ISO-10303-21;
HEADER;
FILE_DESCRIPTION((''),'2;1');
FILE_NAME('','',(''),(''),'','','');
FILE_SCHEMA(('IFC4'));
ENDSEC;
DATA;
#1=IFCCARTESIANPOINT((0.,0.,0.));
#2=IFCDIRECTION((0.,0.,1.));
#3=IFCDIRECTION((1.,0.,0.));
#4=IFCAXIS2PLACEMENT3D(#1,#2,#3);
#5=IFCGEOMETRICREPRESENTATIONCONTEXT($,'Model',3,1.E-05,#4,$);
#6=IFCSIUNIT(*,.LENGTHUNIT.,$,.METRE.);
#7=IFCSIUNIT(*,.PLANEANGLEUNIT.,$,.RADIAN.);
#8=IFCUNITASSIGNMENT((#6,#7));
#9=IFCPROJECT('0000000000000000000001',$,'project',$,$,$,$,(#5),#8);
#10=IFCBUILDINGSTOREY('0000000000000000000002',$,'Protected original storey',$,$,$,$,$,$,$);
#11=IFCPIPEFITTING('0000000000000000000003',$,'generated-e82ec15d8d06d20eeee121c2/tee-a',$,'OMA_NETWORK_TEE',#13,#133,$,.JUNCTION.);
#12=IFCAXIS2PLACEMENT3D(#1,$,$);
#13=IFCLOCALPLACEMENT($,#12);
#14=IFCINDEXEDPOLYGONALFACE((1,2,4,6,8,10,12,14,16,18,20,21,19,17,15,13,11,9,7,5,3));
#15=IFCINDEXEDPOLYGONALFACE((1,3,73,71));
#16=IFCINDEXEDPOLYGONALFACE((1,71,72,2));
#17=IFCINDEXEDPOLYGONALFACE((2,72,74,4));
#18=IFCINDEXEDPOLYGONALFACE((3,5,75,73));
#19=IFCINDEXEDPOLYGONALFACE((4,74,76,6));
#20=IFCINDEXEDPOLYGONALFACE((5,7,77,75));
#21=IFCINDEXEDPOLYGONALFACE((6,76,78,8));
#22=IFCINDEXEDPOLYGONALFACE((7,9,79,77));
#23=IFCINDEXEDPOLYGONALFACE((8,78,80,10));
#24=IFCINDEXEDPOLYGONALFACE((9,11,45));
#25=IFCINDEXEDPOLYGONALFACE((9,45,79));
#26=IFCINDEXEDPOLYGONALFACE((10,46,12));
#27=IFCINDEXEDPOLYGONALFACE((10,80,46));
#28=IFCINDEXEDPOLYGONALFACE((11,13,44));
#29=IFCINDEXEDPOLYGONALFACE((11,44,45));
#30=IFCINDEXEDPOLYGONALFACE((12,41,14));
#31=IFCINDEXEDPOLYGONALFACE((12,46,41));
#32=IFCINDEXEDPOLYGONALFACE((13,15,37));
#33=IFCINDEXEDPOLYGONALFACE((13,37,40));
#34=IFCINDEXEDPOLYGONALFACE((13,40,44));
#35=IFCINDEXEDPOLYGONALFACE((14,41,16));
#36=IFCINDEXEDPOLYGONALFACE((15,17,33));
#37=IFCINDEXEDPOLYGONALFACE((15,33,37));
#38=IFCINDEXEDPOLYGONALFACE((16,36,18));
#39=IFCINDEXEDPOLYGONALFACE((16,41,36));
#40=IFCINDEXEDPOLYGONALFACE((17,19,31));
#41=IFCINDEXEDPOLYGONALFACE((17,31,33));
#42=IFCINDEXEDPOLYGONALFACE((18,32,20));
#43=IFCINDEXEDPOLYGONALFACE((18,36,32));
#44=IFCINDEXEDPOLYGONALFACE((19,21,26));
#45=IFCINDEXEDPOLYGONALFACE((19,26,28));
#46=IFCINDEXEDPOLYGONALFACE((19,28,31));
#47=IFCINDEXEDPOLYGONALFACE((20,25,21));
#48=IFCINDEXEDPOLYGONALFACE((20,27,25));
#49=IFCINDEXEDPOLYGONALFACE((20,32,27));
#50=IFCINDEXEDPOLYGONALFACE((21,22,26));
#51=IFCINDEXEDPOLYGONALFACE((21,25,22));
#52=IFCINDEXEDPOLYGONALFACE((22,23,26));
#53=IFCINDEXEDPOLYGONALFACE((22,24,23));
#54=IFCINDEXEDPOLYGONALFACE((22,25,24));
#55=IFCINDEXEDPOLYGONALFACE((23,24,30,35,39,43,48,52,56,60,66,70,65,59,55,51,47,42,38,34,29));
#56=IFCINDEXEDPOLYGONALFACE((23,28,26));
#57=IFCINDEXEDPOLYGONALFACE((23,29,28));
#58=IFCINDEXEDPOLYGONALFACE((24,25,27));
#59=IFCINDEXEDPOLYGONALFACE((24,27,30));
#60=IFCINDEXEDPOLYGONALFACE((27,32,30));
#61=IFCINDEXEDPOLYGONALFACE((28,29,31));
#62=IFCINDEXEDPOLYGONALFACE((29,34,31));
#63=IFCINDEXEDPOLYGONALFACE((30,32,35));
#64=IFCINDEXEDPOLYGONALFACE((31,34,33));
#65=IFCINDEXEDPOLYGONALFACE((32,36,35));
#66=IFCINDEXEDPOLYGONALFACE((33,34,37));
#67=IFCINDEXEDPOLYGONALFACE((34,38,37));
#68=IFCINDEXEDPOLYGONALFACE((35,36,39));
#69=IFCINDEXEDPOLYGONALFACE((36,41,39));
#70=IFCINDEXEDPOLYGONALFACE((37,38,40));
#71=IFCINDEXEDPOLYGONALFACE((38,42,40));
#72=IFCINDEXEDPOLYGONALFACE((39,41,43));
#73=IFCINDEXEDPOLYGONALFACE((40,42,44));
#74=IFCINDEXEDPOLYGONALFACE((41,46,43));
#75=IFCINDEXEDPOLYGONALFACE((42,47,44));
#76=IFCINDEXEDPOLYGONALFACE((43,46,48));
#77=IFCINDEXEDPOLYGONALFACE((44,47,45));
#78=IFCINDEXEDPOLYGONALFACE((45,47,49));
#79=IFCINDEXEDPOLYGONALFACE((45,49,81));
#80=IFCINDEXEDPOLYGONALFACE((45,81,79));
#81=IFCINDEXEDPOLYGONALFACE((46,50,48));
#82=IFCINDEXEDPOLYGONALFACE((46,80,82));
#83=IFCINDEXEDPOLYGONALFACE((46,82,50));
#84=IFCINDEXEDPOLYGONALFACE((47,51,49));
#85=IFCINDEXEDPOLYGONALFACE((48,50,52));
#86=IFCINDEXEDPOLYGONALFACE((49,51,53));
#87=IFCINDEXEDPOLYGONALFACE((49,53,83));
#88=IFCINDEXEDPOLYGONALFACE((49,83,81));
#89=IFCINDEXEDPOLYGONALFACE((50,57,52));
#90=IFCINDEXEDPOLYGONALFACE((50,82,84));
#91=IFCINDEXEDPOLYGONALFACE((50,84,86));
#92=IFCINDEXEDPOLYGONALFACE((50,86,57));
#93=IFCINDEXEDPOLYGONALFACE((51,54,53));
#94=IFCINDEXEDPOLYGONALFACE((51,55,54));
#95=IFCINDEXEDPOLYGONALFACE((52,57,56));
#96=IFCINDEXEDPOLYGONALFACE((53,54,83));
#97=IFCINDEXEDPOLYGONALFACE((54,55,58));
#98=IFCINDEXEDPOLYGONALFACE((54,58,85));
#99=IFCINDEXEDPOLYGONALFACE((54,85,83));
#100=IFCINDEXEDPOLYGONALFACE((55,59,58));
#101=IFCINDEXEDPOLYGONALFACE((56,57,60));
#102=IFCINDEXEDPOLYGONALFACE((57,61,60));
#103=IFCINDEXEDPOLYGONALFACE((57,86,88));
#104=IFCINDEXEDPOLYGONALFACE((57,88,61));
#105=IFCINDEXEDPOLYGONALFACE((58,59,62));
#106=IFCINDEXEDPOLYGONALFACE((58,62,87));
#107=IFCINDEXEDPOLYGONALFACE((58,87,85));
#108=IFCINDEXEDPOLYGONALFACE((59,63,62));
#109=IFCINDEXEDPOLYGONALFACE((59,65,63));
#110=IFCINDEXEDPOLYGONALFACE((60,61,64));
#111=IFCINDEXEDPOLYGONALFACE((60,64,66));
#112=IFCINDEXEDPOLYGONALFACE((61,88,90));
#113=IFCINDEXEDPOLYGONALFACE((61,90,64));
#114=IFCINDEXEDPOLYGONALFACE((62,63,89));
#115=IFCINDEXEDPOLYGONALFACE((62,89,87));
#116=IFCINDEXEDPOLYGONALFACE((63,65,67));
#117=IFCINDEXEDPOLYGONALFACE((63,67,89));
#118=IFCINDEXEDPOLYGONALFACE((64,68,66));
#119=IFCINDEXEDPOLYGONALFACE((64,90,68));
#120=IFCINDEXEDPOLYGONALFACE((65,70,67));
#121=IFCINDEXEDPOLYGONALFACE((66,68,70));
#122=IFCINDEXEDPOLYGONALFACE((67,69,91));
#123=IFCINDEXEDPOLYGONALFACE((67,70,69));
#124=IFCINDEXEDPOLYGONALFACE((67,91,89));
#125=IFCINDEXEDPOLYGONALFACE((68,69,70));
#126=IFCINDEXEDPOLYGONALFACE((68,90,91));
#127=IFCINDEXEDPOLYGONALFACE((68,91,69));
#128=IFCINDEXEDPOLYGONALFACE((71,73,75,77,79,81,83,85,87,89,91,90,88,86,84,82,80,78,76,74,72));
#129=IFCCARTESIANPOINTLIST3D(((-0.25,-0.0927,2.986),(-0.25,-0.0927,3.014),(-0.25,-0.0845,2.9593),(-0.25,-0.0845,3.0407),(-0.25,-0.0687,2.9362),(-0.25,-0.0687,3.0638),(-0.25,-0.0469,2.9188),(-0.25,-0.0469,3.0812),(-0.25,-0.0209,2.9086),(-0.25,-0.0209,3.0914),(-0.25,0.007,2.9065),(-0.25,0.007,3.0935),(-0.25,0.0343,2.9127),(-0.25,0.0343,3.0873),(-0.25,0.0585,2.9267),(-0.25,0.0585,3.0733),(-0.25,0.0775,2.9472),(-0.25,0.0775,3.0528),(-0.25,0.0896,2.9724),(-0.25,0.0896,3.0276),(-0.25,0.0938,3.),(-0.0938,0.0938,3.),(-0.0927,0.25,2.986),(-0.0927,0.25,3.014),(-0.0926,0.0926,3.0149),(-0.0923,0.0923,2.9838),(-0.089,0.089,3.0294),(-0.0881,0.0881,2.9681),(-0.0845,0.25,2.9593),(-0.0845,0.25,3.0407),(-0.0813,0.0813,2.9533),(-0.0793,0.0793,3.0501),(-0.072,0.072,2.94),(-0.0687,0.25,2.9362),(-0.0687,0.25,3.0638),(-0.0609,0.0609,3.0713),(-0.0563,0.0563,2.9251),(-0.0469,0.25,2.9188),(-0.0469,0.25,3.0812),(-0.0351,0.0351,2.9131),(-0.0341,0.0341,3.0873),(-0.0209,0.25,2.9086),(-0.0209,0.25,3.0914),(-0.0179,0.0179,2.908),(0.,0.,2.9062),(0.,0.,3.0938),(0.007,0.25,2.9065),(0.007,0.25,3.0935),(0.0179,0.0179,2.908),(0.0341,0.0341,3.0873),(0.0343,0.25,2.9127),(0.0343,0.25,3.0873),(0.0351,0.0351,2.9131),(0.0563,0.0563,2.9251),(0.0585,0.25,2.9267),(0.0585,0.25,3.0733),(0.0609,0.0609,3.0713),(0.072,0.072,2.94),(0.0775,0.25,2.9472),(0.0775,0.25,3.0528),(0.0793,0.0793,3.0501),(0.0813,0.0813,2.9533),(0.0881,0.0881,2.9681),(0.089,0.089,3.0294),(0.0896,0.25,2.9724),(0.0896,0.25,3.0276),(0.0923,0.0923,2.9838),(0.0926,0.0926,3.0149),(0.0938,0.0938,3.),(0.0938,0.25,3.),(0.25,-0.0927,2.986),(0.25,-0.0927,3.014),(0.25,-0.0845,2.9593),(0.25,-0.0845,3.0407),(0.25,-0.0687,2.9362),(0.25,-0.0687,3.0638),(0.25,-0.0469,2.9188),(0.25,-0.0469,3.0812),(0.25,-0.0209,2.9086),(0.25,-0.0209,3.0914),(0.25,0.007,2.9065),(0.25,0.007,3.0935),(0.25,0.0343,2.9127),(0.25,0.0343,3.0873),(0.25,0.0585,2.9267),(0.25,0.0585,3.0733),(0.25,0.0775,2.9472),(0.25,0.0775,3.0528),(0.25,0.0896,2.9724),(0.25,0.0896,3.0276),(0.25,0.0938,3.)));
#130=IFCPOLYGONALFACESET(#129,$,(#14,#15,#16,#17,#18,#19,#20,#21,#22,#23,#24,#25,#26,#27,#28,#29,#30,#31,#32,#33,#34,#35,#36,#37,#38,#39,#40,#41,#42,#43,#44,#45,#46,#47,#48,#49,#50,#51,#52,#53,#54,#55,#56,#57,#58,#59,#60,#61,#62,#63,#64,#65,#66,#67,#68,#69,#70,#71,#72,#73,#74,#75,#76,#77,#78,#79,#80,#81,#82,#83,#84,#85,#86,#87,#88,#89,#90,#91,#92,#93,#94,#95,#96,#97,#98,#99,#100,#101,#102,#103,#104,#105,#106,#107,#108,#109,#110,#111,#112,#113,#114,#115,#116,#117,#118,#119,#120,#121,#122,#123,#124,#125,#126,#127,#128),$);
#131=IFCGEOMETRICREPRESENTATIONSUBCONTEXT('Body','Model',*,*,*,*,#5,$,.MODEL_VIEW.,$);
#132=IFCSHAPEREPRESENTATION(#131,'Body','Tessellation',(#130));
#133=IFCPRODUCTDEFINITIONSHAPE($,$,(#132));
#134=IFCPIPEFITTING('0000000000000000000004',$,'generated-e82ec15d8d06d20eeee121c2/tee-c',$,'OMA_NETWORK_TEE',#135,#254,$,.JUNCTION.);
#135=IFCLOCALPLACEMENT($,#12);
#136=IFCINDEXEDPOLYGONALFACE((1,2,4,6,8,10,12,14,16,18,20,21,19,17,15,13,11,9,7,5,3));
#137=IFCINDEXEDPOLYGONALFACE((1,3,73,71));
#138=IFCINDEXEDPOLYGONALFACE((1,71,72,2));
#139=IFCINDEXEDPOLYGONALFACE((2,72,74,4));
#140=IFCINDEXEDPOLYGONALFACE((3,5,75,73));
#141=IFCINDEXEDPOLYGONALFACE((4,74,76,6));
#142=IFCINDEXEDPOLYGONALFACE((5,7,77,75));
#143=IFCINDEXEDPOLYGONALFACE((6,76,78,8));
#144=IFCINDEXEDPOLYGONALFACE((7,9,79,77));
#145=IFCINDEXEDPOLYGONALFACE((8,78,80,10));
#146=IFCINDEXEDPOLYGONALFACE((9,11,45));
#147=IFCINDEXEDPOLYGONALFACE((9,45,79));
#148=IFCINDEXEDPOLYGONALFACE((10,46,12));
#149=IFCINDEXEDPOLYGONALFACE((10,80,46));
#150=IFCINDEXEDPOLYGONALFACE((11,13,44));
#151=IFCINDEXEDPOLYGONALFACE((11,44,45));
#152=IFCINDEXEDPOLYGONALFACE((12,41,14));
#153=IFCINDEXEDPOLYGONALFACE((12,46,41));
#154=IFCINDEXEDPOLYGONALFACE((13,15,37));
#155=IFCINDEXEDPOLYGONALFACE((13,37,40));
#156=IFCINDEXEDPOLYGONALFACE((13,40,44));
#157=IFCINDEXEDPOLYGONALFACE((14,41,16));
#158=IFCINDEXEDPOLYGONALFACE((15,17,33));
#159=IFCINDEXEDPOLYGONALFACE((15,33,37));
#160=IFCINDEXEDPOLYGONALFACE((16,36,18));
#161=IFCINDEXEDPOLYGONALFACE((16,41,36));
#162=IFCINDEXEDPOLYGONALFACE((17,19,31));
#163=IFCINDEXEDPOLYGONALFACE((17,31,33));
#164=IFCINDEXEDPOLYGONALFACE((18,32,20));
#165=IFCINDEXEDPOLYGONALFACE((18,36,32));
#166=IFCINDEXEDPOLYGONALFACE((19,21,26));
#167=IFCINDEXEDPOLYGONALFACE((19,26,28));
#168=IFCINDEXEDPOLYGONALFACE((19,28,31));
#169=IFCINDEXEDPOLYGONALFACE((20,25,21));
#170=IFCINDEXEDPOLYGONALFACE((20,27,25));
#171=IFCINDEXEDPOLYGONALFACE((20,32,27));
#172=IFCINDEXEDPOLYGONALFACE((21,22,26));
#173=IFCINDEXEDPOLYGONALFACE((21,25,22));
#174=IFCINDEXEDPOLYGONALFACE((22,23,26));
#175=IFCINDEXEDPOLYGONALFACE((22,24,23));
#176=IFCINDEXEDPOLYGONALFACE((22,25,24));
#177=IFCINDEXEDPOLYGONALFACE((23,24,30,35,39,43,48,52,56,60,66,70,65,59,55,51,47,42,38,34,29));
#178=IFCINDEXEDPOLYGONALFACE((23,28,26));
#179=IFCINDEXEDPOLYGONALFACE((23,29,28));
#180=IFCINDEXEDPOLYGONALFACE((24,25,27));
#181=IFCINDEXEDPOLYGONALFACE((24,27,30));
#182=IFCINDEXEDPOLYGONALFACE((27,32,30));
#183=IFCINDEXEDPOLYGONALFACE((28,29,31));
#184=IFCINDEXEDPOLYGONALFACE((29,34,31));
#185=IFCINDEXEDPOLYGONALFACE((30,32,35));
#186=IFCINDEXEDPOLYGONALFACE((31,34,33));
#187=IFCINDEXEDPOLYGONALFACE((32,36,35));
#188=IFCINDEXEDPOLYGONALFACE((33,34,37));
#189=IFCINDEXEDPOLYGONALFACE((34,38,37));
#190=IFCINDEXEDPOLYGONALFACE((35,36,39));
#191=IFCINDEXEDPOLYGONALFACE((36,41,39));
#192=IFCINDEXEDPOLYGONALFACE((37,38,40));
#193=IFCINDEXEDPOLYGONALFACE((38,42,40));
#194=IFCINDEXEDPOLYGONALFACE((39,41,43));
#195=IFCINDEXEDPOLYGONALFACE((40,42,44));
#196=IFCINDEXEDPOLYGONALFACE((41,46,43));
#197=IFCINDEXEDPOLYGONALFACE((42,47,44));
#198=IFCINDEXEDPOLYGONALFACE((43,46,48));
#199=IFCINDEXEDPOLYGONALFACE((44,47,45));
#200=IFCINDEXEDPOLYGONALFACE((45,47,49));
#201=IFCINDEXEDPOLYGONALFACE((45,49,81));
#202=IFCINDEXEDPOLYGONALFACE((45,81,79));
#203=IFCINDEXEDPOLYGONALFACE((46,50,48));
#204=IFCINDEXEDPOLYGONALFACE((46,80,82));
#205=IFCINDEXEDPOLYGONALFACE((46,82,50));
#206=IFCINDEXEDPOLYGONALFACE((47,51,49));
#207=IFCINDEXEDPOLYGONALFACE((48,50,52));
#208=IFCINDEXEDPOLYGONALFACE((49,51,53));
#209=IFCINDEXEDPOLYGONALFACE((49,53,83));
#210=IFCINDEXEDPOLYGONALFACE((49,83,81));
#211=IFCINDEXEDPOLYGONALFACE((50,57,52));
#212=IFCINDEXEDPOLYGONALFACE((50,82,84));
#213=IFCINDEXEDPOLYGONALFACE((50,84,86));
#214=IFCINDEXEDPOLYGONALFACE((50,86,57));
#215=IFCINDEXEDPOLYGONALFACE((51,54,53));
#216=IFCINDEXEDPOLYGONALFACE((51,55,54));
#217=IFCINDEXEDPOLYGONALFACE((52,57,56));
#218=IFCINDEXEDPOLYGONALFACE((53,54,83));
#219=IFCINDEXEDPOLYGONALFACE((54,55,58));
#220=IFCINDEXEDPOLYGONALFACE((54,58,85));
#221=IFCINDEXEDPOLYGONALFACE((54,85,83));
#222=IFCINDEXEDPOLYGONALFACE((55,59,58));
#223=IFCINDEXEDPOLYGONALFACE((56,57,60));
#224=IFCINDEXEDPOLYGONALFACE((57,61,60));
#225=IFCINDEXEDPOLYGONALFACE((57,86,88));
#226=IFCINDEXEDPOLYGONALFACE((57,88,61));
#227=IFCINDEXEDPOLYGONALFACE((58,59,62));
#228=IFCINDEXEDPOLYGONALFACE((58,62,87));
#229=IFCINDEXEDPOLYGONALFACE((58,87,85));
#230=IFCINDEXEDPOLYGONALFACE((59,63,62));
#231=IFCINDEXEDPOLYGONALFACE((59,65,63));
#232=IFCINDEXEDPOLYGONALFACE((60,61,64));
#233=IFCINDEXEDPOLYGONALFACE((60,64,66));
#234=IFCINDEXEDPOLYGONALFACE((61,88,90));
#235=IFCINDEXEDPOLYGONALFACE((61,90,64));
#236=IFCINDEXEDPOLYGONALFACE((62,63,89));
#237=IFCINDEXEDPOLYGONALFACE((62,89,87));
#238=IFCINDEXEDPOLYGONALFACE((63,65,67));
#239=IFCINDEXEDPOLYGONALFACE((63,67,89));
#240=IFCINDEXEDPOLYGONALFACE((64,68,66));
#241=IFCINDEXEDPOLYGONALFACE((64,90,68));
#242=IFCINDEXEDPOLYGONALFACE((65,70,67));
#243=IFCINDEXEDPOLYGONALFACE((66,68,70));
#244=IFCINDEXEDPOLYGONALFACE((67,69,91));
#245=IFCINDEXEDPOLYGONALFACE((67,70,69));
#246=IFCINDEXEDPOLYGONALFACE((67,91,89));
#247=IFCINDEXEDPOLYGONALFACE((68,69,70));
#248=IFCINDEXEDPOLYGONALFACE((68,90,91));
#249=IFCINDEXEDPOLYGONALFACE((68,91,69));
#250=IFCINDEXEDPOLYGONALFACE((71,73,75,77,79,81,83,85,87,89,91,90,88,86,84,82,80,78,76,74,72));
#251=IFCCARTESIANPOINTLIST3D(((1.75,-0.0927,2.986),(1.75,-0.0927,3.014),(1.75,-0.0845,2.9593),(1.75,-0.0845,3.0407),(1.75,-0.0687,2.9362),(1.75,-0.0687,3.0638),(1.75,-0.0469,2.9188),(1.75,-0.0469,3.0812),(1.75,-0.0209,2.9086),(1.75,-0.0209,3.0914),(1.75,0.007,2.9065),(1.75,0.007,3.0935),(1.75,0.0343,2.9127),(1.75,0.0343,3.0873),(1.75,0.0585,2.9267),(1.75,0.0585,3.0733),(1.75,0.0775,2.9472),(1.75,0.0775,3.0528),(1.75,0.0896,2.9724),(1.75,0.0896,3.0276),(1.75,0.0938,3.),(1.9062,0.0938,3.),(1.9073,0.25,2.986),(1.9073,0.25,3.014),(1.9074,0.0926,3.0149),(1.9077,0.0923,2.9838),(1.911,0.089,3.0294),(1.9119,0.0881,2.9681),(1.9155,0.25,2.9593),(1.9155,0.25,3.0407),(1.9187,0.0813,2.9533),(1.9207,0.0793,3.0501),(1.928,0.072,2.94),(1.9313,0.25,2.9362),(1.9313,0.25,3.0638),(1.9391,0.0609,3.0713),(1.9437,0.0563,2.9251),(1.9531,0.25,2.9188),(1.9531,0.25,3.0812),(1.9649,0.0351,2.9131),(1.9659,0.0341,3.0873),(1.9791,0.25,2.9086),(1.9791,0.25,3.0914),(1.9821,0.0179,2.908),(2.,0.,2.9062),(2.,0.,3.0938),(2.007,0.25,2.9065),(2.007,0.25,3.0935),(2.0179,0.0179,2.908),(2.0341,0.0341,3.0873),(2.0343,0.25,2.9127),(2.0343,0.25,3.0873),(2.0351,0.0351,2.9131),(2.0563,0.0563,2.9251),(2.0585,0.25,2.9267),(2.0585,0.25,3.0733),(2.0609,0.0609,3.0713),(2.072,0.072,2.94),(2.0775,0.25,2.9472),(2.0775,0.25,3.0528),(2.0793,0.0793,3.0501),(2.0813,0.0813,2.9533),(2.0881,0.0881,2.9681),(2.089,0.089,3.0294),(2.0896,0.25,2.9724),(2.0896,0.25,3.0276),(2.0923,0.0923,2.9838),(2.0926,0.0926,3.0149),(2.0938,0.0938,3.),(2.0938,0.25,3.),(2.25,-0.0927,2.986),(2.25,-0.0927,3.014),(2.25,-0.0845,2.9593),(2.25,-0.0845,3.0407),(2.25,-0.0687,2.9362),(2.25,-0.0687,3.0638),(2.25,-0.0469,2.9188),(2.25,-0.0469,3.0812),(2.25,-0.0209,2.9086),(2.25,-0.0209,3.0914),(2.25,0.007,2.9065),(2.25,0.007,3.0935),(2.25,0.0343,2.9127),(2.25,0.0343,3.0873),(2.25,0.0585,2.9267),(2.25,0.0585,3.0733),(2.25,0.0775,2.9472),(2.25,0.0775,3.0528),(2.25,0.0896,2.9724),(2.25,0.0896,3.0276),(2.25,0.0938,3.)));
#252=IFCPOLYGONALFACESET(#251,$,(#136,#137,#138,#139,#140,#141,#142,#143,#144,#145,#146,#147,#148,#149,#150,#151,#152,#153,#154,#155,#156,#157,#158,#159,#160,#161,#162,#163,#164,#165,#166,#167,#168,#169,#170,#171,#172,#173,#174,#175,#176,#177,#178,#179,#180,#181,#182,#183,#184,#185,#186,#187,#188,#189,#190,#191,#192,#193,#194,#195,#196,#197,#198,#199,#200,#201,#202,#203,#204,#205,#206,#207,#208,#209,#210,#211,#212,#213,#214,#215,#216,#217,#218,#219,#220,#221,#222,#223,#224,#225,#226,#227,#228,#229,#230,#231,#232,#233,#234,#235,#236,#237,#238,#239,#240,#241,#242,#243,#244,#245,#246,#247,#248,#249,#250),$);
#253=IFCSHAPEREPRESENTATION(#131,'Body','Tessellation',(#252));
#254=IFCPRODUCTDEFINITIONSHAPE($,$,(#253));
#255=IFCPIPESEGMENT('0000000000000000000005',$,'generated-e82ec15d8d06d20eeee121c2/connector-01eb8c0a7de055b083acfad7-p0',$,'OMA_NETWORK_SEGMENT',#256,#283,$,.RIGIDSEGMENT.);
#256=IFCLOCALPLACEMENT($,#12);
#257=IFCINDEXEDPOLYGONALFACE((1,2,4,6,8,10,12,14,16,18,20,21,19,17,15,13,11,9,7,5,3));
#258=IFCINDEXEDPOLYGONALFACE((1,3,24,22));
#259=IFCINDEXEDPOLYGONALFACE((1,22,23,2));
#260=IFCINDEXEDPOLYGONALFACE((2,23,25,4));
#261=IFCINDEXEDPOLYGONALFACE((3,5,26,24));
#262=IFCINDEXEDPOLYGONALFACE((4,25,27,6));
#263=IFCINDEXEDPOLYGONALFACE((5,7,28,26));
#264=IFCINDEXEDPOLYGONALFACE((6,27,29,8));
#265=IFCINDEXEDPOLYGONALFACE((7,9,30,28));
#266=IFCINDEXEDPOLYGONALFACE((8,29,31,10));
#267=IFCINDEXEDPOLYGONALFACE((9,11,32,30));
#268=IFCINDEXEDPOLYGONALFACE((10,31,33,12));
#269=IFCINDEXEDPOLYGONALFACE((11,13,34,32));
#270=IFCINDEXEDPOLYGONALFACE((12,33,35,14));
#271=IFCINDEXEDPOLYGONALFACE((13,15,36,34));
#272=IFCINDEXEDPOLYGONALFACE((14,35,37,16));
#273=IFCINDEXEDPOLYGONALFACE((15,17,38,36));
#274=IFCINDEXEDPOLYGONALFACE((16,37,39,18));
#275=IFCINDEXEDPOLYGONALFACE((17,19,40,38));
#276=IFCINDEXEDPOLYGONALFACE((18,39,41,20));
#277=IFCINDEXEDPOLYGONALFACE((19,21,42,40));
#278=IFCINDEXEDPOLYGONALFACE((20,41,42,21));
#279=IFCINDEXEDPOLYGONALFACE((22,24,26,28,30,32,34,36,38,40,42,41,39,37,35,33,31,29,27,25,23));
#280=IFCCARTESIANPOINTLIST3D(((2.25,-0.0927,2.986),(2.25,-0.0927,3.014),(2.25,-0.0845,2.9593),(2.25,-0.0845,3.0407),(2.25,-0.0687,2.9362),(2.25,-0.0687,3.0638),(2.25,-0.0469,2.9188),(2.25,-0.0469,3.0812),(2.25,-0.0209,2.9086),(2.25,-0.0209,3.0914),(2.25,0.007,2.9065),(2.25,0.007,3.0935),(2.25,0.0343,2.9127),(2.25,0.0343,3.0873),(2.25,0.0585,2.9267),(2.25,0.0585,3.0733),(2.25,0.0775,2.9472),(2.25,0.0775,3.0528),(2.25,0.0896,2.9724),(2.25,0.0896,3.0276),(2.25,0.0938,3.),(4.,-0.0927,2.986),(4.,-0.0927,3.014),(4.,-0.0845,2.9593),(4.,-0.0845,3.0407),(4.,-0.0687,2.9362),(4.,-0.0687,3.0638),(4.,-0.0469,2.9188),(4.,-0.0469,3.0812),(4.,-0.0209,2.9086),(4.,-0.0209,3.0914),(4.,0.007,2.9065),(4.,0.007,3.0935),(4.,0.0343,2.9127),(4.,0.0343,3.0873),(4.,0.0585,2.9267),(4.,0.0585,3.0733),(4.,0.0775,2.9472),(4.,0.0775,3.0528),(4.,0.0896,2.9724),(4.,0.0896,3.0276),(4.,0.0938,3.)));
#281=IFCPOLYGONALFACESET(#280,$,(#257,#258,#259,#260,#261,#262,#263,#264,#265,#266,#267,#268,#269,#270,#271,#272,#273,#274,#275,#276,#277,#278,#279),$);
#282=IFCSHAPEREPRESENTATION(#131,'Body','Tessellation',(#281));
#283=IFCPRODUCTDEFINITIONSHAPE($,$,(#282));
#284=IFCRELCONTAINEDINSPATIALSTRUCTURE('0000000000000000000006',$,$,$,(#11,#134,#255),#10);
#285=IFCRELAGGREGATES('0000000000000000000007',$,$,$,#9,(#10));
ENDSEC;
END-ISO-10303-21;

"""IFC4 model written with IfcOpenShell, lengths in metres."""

from ifc_helpers import new_model, si_unit, frame, origin_with_axes, origin_2d, place, context, subcontext, project, spatial, circle, extrude, boolean, element, save


model = new_model("IFC4")

# Units and contexts
model_context = context("Model", 3, precision=1e-05, world=origin_with_axes())
body_context = subcontext(model_context, "Body", "Model", "MODEL_VIEW")
ifc_project = project(units=[si_unit("LENGTHUNIT", "METRE"), si_unit("PLANEANGLEUNIT", "RADIAN")], contexts=[model_context])

# Storey
storey = spatial("IfcBuildingStorey", under=ifc_project, Name="Protected original storey")

# Pipe fittings
pipe_fitting_1_placement = place(None, origin_with_axes())
element("IfcPipeFitting", 1, at=pipe_fitting_1_placement, inside=storey, Name="generated-e82ec15d8d06d20eeee121c2/tee-a", ObjectType="OMA_NETWORK_TEE", PredefinedType="JUNCTION", context=body_context, shape_type="CSG", body=[
    boolean("UNION", extrude(circle(Radius=0.0938, at=origin_2d()), frame((-0.25, 0.0, 3.0), z_axis=(1.0, 0.0, 0.0), x_axis=(0.0, 1.0, 0.0)), (0.0, 0.0, 1.0), 0.5), extrude(circle(Radius=0.0938, at=origin_2d()), frame((0.0, 0.0, 3.0), z_axis=(0.0, 1.0, 0.0), x_axis=(1.0, 0.0, 0.0)), (0.0, 0.0, 1.0), 0.25)),
])
pipe_fitting_2_placement = place(None, origin_with_axes())
element("IfcPipeFitting", 2, at=pipe_fitting_2_placement, inside=storey, Name="generated-e82ec15d8d06d20eeee121c2/tee-c", ObjectType="OMA_NETWORK_TEE", PredefinedType="JUNCTION", context=body_context, shape_type="CSG", body=[
    boolean("UNION", extrude(circle(Radius=0.0938, at=origin_2d()), frame((1.75, 0.0, 3.0), z_axis=(1.0, 0.0, 0.0), x_axis=(0.0, 1.0, 0.0)), (0.0, 0.0, 1.0), 0.5), extrude(circle(Radius=0.0938, at=origin_2d()), frame((2.0, 0.0, 3.0), z_axis=(0.0, 1.0, 0.0), x_axis=(1.0, 0.0, 0.0)), (0.0, 0.0, 1.0), 0.25)),
])

# Pipe segment
pipe_segment_1_placement = place(None, origin_with_axes())
element("IfcPipeSegment", 3, at=pipe_segment_1_placement, inside=storey, Name="generated-e82ec15d8d06d20eeee121c2/connector-01eb8c0a7de055b083acfad7-p0", ObjectType="OMA_NETWORK_SEGMENT", PredefinedType="RIGIDSEGMENT", context=body_context, shape_type="SweptSolid", body=[
    extrude(circle(Radius=0.0938, at=origin_2d()), frame((2.25, 0.0, 3.0), z_axis=(1.0, 0.0, 0.0), x_axis=(0.0, 1.0, 0.0)), (0.0, 0.0, 1.0), 1.75),
])

save(model, "model.ifc")
